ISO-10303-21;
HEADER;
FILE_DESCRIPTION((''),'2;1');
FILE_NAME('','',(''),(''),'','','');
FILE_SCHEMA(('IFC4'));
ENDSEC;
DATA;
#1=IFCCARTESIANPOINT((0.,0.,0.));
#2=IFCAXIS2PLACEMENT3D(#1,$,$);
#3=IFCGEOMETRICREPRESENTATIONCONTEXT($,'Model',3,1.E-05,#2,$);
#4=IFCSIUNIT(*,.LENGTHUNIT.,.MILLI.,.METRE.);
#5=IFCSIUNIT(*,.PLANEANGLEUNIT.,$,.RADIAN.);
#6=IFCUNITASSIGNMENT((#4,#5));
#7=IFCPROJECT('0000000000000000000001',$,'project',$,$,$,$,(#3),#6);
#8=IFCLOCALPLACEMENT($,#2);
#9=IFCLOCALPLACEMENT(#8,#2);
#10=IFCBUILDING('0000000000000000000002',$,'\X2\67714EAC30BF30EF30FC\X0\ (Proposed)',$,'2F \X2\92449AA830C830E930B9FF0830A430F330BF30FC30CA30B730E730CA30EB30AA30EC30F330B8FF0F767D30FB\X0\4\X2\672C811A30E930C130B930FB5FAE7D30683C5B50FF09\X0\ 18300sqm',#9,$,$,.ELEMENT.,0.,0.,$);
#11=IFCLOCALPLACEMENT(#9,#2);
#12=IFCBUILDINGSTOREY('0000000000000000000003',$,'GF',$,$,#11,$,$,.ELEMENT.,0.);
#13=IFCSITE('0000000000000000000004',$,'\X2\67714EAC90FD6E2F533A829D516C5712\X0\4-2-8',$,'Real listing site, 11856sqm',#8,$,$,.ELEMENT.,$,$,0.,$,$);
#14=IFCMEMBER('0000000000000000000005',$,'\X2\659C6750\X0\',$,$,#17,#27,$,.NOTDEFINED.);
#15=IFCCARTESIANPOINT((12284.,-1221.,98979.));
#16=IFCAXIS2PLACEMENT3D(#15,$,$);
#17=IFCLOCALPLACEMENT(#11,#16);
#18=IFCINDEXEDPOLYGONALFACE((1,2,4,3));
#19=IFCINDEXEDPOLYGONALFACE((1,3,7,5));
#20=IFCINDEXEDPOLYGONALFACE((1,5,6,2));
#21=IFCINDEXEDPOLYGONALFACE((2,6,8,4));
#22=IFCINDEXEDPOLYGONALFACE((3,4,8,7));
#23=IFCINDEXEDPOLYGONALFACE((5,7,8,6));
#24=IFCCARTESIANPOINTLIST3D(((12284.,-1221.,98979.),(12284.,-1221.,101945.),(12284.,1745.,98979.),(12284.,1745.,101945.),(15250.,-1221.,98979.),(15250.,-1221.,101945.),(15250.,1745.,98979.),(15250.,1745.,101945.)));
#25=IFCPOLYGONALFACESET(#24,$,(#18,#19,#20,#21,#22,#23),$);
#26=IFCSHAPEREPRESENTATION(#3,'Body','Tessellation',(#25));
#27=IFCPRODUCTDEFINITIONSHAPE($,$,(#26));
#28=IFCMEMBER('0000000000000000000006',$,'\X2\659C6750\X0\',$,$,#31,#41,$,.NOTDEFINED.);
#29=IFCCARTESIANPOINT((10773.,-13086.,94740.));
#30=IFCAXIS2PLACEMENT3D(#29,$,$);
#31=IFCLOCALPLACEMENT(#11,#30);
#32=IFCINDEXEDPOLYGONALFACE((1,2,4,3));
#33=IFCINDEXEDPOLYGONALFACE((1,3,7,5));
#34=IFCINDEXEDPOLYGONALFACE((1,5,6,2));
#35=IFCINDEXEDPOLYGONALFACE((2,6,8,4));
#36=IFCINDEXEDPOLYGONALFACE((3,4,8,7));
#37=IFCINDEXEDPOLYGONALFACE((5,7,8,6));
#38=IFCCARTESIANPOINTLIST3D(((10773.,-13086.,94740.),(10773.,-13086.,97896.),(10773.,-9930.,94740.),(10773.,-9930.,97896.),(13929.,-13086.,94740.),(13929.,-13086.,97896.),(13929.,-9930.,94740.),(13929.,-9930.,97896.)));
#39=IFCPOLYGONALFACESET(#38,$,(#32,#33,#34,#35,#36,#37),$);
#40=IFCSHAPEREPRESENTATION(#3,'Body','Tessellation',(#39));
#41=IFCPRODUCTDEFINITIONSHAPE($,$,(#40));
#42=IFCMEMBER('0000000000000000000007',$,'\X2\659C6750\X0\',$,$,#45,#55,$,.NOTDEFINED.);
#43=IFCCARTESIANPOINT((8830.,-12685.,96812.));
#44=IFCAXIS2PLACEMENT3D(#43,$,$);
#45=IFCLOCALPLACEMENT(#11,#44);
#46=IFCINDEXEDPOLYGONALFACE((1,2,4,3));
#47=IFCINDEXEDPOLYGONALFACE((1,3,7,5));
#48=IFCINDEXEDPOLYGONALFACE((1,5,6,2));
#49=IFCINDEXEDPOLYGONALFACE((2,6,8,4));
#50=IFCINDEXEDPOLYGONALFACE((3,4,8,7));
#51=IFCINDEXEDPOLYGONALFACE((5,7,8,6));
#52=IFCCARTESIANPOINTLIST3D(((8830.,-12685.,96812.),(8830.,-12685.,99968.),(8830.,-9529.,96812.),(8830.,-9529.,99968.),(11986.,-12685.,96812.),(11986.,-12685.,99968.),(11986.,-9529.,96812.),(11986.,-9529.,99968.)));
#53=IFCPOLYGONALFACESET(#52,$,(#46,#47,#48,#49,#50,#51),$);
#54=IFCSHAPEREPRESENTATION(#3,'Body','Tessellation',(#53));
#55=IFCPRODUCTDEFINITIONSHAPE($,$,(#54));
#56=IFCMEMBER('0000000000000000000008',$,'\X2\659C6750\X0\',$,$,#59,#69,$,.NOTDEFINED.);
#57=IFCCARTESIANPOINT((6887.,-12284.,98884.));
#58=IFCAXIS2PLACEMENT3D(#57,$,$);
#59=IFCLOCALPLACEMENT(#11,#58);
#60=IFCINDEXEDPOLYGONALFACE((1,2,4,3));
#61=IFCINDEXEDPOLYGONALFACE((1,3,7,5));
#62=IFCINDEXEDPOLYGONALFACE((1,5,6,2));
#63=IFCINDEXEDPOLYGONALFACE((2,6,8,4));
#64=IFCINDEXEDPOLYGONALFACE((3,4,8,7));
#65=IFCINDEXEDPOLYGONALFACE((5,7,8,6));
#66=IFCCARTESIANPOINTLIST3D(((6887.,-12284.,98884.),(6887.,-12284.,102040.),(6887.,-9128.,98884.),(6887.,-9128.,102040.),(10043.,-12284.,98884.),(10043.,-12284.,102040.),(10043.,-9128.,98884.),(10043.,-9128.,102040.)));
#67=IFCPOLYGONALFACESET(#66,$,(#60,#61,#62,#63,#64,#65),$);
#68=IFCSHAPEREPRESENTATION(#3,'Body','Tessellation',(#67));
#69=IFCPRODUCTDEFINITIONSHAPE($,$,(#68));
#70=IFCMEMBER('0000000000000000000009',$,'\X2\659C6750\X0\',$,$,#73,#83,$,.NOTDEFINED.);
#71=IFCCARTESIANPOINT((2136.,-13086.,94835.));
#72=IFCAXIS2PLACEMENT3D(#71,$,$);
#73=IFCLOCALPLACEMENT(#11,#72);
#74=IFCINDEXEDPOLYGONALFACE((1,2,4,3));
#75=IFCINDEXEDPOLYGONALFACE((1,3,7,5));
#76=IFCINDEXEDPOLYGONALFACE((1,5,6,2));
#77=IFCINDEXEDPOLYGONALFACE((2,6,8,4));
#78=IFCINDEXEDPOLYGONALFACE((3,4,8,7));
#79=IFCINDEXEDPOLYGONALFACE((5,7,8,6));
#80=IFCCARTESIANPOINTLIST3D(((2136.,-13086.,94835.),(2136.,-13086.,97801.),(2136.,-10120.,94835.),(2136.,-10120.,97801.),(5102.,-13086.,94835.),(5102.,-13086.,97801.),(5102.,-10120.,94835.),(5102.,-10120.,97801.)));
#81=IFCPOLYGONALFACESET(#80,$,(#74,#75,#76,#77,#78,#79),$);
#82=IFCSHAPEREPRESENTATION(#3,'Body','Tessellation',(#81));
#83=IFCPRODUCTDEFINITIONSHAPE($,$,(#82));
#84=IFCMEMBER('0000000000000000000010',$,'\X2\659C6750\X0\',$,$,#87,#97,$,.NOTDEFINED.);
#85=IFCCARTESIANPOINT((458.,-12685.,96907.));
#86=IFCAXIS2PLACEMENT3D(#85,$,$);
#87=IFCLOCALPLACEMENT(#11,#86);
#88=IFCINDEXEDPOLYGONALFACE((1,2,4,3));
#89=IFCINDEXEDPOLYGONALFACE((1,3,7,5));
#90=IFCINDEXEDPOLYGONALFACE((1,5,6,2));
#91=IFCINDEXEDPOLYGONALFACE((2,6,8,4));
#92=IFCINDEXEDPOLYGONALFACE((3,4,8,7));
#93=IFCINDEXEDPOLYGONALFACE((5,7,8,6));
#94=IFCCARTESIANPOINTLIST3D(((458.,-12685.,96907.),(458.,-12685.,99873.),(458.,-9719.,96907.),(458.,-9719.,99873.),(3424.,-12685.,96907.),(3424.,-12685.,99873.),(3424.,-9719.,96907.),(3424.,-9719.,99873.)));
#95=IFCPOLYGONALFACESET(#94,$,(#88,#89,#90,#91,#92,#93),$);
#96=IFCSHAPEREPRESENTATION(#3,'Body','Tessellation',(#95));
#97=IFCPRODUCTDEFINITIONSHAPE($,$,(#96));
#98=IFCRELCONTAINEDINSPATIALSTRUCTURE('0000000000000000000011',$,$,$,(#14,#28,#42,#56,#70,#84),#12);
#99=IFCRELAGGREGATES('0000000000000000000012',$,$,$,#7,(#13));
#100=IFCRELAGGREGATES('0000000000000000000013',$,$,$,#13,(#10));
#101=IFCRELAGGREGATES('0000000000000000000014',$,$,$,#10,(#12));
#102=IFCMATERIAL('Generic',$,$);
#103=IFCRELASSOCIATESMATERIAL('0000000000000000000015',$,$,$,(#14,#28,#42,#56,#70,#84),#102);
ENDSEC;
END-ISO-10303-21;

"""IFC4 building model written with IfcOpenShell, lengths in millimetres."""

from ifc_helpers import new_model, si_unit, frame, frame_2d, origin, place, context, project, spatial, rectangle, extrude, material, element, save


model = new_model("IFC4")

# Units and contexts
model_context = context("Model", 3, precision=1e-05, world=origin())
ifc_project = project(units=[si_unit("LENGTHUNIT", "METRE", prefix="MILLI"), si_unit("PLANEANGLEUNIT", "RADIAN")], contexts=[model_context])

# Site, building, storey
site_placement = place(None, origin())
site = spatial("IfcSite", under=ifc_project, at=site_placement, Name="東京都港区芝公園4-2-8", ObjectType="Real listing site, 11856sqm", CompositionType="ELEMENT", RefElevation=0.0)
building_placement = place(site_placement, origin())
building = spatial("IfcBuilding", under=site, at=building_placement, Name="東京タワー (Proposed)", ObjectType="2F 鉄骨トラス（インターナショナルオレンジ／白・4本脚ラチス・微細格子） 18300sqm", CompositionType="ELEMENT", ElevationOfRefHeight=0.0, ElevationOfTerrain=0.0)
storey_placement = place(building_placement, origin())
storey = spatial("IfcBuildingStorey", under=building, at=storey_placement, Name="GF", CompositionType="ELEMENT", Elevation=0.0)

# Shared definitions
ifc_material = material(Name="Generic")

# Members
member_1_placement = place(storey_placement, frame((12284.0, -1221.0, 98979.0)))
element("IfcMember", 1, at=member_1_placement, inside=storey, material=ifc_material, Name="斜材", PredefinedType="NOTDEFINED", context=model_context, shape_type="SweptSolid", body=[
    extrude(rectangle(XDim=2966.0, YDim=2966.0, at=frame_2d((1483.0, 1483.0))), frame((12284.0, -1221.0, 98979.0)), (0.0, 0.0, 1.0), 2966.0),
])
member_2_placement = place(storey_placement, frame((10773.0, -13086.0, 94740.0)))
element("IfcMember", 2, at=member_2_placement, inside=storey, material=ifc_material, Name="斜材", PredefinedType="NOTDEFINED", context=model_context, shape_type="SweptSolid", body=[
    extrude(rectangle(XDim=3156.0, YDim=3156.0, at=frame_2d((1578.0, 1578.0))), frame((10773.0, -13086.0, 94740.0)), (0.0, 0.0, 1.0), 3156.0),
])
member_3_placement = place(storey_placement, frame((8830.0, -12685.0, 96812.0)))
element("IfcMember", 3, at=member_3_placement, inside=storey, material=ifc_material, Name="斜材", PredefinedType="NOTDEFINED", context=model_context, shape_type="SweptSolid", body=[
    extrude(rectangle(XDim=3156.0, YDim=3156.0, at=frame_2d((1578.0, 1578.0))), frame((8830.0, -12685.0, 96812.0)), (0.0, 0.0, 1.0), 3156.0),
])
member_4_placement = place(storey_placement, frame((6887.0, -12284.0, 98884.0)))
element("IfcMember", 4, at=member_4_placement, inside=storey, material=ifc_material, Name="斜材", PredefinedType="NOTDEFINED", context=model_context, shape_type="SweptSolid", body=[
    extrude(rectangle(XDim=3156.0, YDim=3156.0, at=frame_2d((1578.0, 1578.0))), frame((6887.0, -12284.0, 98884.0)), (0.0, 0.0, 1.0), 3156.0),
])
member_5_placement = place(storey_placement, frame((2136.0, -13086.0, 94835.0)))
element("IfcMember", 5, at=member_5_placement, inside=storey, material=ifc_material, Name="斜材", PredefinedType="NOTDEFINED", context=model_context, shape_type="SweptSolid", body=[
    extrude(rectangle(XDim=2966.0, YDim=2966.0, at=frame_2d((1483.0, 1483.0))), frame((2136.0, -13086.0, 94835.0)), (0.0, 0.0, 1.0), 2966.0),
])
member_6_placement = place(storey_placement, frame((458.0, -12685.0, 96907.0)))
element("IfcMember", 6, at=member_6_placement, inside=storey, material=ifc_material, Name="斜材", PredefinedType="NOTDEFINED", context=model_context, shape_type="SweptSolid", body=[
    extrude(rectangle(XDim=2966.0, YDim=2966.0, at=frame_2d((1483.0, 1483.0))), frame((458.0, -12685.0, 96907.0)), (0.0, 0.0, 1.0), 2966.0),
])

save(model, "model.ifc")
